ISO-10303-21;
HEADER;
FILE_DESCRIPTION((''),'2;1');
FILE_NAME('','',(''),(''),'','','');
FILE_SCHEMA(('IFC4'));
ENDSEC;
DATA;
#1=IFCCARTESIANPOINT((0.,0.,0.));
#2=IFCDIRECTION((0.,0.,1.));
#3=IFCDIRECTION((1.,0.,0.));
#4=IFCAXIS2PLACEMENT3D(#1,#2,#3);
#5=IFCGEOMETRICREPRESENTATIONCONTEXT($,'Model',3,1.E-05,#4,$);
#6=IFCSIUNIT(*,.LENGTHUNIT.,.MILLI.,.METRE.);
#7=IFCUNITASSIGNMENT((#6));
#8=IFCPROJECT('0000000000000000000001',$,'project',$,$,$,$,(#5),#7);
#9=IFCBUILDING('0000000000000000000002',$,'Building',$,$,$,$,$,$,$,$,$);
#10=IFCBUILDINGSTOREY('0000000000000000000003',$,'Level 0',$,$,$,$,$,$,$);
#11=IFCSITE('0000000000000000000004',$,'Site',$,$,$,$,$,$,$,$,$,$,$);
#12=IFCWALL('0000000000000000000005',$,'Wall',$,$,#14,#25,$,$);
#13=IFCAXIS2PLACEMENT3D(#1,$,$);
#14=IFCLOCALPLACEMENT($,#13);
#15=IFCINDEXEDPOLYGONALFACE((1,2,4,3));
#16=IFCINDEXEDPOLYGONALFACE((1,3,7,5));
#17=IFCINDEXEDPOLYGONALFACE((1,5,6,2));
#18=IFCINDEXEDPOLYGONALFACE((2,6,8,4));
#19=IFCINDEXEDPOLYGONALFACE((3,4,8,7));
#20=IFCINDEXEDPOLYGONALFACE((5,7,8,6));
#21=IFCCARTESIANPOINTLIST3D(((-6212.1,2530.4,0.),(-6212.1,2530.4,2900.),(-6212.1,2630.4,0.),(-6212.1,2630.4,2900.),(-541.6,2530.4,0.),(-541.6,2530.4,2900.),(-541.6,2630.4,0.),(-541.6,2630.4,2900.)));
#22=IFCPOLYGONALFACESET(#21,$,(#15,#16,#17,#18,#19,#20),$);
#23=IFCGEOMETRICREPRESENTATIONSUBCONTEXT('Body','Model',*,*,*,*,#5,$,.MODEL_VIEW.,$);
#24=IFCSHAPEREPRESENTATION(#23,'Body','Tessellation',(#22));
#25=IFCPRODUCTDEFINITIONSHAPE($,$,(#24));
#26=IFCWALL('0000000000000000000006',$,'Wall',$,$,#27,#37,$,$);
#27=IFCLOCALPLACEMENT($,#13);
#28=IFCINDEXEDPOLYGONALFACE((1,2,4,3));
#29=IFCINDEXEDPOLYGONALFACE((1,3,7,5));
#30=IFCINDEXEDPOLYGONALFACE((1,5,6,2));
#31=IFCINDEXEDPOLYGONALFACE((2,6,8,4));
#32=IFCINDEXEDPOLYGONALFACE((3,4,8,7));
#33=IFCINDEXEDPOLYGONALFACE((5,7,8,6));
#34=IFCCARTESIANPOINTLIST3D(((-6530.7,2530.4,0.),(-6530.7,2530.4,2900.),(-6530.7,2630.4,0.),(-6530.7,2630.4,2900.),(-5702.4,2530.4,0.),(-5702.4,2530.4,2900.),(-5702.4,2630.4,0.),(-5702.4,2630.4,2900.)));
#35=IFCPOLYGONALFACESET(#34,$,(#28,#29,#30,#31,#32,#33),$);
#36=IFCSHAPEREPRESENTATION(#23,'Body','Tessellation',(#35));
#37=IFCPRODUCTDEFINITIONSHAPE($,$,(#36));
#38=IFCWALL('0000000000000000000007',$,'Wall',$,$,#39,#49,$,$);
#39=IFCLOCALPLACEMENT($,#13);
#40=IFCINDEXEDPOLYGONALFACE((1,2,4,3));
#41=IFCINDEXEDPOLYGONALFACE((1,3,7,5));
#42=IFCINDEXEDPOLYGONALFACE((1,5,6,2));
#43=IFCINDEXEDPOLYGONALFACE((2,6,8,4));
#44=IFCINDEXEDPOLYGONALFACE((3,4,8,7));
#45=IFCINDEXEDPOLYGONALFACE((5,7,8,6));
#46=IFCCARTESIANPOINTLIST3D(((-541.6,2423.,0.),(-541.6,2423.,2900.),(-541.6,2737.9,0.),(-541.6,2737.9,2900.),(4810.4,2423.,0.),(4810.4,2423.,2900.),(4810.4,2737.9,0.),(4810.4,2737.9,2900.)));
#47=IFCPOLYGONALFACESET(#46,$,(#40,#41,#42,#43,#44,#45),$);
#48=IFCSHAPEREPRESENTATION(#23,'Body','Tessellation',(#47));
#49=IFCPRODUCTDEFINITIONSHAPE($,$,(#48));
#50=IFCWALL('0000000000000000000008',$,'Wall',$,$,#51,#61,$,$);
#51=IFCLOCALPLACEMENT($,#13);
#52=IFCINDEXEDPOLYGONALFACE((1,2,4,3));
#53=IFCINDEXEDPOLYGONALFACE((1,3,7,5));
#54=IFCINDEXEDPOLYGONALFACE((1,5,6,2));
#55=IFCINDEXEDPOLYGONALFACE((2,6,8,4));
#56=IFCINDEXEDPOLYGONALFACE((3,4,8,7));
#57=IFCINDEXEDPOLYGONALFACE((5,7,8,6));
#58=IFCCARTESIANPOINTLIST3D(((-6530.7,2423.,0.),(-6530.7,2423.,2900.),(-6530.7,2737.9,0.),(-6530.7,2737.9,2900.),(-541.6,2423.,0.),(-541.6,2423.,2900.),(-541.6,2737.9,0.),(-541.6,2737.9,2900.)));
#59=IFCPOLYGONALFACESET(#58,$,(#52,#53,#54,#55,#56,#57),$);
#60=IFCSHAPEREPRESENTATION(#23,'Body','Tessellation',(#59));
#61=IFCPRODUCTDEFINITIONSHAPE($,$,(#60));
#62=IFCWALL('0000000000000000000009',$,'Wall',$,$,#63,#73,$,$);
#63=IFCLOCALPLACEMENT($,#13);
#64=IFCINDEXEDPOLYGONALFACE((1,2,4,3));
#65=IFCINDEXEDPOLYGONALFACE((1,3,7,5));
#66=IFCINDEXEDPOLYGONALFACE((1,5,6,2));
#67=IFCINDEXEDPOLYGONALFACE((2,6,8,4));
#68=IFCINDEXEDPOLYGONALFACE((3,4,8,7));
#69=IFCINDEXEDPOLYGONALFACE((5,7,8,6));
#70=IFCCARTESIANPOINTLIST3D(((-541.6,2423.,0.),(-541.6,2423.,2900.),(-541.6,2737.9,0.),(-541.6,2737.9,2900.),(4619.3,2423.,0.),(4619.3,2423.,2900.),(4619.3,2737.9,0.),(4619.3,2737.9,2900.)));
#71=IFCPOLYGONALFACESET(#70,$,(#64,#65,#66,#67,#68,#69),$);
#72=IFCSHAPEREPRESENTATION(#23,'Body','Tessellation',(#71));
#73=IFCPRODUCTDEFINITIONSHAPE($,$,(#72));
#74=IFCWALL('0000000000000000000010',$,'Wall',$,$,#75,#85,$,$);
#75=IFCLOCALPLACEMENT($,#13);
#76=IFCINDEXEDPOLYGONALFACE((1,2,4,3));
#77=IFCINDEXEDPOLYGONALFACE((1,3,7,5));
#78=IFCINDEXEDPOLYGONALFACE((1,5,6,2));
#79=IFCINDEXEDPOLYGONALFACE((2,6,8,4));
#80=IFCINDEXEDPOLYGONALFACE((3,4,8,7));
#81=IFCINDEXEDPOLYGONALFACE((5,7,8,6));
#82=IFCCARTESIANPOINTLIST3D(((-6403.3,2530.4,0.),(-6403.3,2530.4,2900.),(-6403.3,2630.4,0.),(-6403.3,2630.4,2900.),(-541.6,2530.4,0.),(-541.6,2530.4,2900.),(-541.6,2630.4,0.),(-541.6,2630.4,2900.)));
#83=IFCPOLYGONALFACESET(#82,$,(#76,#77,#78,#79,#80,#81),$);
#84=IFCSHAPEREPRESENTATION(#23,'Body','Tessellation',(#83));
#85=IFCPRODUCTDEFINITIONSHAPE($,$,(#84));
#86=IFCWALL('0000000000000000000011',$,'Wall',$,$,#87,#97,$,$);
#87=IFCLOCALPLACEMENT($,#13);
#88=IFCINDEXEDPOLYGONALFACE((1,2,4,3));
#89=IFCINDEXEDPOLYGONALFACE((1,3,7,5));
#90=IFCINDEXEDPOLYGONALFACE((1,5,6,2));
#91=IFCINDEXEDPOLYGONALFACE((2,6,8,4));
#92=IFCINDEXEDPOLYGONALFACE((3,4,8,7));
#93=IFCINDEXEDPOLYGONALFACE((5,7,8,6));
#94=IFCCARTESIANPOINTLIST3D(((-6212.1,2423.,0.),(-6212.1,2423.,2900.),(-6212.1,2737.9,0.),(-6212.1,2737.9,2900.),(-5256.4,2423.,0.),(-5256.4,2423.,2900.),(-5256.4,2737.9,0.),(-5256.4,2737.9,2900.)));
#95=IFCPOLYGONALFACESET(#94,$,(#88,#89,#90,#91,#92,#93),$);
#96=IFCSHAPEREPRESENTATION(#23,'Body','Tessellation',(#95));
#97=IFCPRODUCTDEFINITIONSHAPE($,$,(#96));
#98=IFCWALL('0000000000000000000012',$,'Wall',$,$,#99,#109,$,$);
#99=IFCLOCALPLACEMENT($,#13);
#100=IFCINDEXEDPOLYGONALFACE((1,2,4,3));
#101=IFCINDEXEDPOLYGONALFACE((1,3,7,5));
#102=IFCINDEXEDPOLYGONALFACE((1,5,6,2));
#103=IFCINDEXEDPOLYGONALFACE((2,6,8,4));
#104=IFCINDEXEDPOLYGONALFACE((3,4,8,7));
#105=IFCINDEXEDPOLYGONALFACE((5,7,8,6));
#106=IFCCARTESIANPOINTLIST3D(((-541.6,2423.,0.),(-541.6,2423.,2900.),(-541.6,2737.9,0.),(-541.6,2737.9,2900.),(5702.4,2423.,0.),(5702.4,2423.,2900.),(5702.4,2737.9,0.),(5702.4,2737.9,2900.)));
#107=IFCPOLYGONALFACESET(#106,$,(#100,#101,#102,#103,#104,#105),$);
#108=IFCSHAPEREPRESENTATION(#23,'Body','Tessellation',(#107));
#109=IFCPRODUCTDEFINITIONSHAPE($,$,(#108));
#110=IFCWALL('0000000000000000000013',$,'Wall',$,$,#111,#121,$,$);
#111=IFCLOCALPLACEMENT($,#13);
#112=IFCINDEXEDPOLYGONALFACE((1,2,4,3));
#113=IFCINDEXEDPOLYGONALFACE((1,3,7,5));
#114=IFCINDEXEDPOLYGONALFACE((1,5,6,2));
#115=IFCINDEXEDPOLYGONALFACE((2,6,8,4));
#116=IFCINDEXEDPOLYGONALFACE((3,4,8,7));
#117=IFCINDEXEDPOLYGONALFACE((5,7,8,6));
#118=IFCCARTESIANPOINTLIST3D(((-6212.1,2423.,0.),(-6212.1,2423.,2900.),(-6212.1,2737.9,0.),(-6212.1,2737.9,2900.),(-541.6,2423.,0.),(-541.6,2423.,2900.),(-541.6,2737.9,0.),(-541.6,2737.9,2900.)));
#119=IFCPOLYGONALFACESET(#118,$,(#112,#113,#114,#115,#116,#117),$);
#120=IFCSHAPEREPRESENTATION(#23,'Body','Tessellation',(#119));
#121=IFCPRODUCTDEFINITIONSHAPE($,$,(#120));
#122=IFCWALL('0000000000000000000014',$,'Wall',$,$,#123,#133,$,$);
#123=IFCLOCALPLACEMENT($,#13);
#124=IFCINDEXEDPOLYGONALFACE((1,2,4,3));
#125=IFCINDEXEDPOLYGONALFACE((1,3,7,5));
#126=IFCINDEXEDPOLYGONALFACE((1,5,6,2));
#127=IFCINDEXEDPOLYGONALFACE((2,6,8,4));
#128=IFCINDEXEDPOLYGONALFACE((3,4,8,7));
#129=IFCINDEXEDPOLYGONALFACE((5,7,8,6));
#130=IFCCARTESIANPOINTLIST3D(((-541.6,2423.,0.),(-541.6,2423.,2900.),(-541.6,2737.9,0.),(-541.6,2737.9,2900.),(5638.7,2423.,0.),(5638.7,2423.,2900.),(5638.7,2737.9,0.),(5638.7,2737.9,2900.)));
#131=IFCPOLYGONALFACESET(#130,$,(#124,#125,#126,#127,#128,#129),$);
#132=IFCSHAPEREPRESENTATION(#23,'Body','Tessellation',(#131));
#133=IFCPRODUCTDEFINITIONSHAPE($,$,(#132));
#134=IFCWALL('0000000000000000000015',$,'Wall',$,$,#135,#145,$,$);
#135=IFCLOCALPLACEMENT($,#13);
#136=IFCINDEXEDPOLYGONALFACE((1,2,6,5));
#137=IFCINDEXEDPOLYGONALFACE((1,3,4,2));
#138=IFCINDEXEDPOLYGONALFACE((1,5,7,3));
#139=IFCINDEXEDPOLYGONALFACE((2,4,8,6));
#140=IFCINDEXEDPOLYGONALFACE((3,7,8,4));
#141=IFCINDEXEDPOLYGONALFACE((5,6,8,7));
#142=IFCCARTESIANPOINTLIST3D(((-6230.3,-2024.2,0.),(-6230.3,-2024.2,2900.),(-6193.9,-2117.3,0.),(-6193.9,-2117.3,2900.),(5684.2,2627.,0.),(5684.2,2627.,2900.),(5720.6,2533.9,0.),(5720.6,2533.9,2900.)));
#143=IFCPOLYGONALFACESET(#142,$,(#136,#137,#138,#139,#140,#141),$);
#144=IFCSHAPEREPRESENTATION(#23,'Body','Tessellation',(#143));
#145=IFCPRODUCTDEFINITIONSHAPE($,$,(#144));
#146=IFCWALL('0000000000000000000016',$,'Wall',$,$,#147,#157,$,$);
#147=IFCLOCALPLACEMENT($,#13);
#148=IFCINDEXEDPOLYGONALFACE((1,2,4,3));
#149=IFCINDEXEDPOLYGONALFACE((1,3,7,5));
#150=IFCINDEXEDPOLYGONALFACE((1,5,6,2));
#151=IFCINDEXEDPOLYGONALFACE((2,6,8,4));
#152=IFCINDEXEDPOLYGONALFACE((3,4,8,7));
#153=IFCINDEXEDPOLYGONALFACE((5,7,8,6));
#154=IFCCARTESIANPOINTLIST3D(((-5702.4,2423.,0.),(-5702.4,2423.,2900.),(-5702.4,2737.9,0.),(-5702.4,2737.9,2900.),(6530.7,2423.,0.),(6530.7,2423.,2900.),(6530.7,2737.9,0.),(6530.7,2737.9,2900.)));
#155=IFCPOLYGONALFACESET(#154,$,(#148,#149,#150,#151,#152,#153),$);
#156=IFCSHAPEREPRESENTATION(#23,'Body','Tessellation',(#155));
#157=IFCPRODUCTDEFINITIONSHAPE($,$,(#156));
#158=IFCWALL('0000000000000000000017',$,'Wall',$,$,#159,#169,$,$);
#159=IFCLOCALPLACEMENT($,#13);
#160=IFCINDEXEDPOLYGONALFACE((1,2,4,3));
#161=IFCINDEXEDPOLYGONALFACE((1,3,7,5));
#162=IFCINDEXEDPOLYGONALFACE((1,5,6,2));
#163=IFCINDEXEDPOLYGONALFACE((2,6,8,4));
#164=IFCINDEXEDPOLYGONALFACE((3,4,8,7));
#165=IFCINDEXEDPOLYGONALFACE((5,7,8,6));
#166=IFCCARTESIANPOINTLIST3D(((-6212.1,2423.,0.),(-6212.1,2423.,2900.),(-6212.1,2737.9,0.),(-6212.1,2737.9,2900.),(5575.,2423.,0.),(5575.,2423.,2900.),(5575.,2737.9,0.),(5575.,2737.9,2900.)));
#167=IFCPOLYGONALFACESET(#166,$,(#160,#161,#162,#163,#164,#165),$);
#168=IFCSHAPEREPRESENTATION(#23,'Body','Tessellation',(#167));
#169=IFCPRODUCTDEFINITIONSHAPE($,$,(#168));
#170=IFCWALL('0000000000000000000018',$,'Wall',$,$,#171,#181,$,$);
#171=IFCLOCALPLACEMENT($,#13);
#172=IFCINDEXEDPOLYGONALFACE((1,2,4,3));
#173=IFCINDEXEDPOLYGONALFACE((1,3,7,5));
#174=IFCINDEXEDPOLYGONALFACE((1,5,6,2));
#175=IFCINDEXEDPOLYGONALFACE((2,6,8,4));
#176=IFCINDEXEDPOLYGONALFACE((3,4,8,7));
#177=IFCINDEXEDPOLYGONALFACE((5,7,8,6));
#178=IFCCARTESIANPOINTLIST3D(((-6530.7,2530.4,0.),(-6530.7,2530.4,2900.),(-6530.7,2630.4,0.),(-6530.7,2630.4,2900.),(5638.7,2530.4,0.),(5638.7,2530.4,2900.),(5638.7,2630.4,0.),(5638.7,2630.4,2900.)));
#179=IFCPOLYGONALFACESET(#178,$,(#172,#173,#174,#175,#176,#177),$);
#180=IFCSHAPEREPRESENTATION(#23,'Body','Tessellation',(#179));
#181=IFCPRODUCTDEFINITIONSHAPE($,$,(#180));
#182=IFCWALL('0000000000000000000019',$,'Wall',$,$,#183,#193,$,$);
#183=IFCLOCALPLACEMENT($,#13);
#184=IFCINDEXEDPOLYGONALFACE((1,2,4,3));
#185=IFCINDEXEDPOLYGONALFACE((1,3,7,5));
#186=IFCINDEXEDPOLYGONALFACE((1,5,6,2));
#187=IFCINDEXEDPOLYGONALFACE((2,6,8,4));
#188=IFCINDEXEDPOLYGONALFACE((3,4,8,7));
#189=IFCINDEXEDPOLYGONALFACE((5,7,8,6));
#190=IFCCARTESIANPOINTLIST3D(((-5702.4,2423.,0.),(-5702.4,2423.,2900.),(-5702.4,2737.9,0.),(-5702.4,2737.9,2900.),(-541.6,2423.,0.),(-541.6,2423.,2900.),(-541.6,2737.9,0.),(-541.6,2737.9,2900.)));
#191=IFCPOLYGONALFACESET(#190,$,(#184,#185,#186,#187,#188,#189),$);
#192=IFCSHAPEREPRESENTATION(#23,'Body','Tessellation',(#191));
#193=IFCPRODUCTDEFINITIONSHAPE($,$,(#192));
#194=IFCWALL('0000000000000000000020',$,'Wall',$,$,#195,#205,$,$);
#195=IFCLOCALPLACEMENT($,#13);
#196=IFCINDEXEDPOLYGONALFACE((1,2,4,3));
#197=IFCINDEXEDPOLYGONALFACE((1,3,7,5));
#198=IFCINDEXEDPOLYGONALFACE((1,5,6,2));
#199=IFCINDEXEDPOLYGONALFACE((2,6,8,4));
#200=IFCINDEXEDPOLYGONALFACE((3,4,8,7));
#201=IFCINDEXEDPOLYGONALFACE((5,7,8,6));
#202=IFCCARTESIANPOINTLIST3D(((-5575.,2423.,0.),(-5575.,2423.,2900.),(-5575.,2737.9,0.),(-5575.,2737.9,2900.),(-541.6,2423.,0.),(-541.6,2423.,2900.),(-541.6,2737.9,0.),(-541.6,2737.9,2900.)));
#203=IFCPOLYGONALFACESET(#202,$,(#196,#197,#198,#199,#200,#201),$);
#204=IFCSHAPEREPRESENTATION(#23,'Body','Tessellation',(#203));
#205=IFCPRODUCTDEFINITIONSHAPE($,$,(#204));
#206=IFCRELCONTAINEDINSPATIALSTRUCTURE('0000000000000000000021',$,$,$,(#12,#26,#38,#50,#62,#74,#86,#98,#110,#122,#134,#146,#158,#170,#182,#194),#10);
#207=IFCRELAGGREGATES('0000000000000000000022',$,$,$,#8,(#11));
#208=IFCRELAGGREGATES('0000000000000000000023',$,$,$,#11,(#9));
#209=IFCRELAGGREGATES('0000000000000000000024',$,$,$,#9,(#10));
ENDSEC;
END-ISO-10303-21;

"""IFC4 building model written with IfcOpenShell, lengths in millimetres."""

from ifc_helpers import new_model, si_unit, frame, origin_with_axes, place, context, subcontext, project, spatial, indexed_curve, outline, extrude, element, save


model = new_model("IFC4")

# Units and contexts
model_context = context("Model", 3, precision=1e-05, world=origin_with_axes())
body_context = subcontext(model_context, "Body", "Model", "MODEL_VIEW")
ifc_project = project(units=[si_unit("LENGTHUNIT", "METRE", prefix="MILLI")], contexts=[model_context])

# Site, building, storey
site = spatial("IfcSite", under=ifc_project, Name="Site")
building = spatial("IfcBuilding", under=site, Name="Building")
storey = spatial("IfcBuildingStorey", under=building, Name="Level 0")

# Walls
wall_1_placement = place(None, frame((-6212.1, 2530.4, 0.0), z_axis=(0.0, 0.0, 1.0), x_axis=(1.0, 0.0, 0.0)))
element("IfcWall", 1, at=wall_1_placement, inside=storey, Name="Wall", context=body_context, shape_type="SweptSolid", body=[
    extrude(outline(indexed_curve([(0.0, 0.0), (0.0, 99.9), (5670.5, 99.9), (5670.5, 0.0), (0.0, 0.0)], self_intersect=False)), origin_with_axes(), (0.0, 0.0, 1.0), 2900.0),
])
wall_2_placement = place(None, frame((-6530.7, 2530.4, 0.0), z_axis=(0.0, 0.0, 1.0), x_axis=(1.0, 0.0, 0.0)))
element("IfcWall", 2, at=wall_2_placement, inside=storey, Name="Wall", context=body_context, shape_type="SweptSolid", body=[
    extrude(outline(indexed_curve([(0.0, 0.0), (0.0, 99.9), (828.3, 99.9), (828.3, 0.0), (0.0, 0.0)], self_intersect=False)), origin_with_axes(), (0.0, 0.0, 1.0), 2900.0),
])
wall_3_placement = place(None, frame((-541.6, 2423.0, 0.0), z_axis=(0.0, 0.0, 1.0), x_axis=(1.0, 0.0, 0.0)))
element("IfcWall", 3, at=wall_3_placement, inside=storey, Name="Wall", context=body_context, shape_type="SweptSolid", body=[
    extrude(outline(indexed_curve([(0.0, 0.0), (0.0, 314.9), (5352.0, 314.9), (5352.0, 0.0), (0.0, 0.0)], self_intersect=False)), origin_with_axes(), (0.0, 0.0, 1.0), 2900.0),
])
wall_4_placement = place(None, frame((-6530.7, 2423.0, 0.0), z_axis=(0.0, 0.0, 1.0), x_axis=(1.0, 0.0, 0.0)))
element("IfcWall", 4, at=wall_4_placement, inside=storey, Name="Wall", context=body_context, shape_type="SweptSolid", body=[
    extrude(outline(indexed_curve([(0.0, 0.0), (0.0, 314.9), (5989.1, 314.9), (5989.1, 0.0), (0.0, 0.0)], self_intersect=False)), origin_with_axes(), (0.0, 0.0, 1.0), 2900.0),
])
wall_5_placement = place(None, frame((-541.6, 2423.0, 0.0), z_axis=(0.0, 0.0, 1.0), x_axis=(1.0, 0.0, 0.0)))
element("IfcWall", 5, at=wall_5_placement, inside=storey, Name="Wall", context=body_context, shape_type="SweptSolid", body=[
    extrude(outline(indexed_curve([(0.0, 0.0), (0.0, 314.9), (5160.8, 314.9), (5160.8, 0.0), (0.0, 0.0)], self_intersect=False)), origin_with_axes(), (0.0, 0.0, 1.0), 2900.0),
])
wall_6_placement = place(None, frame((-6403.3, 2530.4, 0.0), z_axis=(0.0, 0.0, 1.0), x_axis=(1.0, 0.0, 0.0)))
element("IfcWall", 6, at=wall_6_placement, inside=storey, Name="Wall", context=body_context, shape_type="SweptSolid", body=[
    extrude(outline(indexed_curve([(0.0, 0.0), (0.0, 99.9), (5861.7, 99.9), (5861.7, 0.0), (0.0, 0.0)], self_intersect=False)), origin_with_axes(), (0.0, 0.0, 1.0), 2900.0),
])
wall_7_placement = place(None, frame((-6212.1, 2423.0, 0.0), z_axis=(0.0, 0.0, 1.0), x_axis=(1.0, 0.0, 0.0)))
element("IfcWall", 7, at=wall_7_placement, inside=storey, Name="Wall", context=body_context, shape_type="SweptSolid", body=[
    extrude(outline(indexed_curve([(0.0, 0.0), (0.0, 314.9), (955.7, 314.9), (955.7, 0.0), (0.0, 0.0)], self_intersect=False)), origin_with_axes(), (0.0, 0.0, 1.0), 2900.0),
])
wall_8_placement = place(None, frame((-541.6, 2423.0, 0.0), z_axis=(0.0, 0.0, 1.0), x_axis=(1.0, 0.0, 0.0)))
element("IfcWall", 8, at=wall_8_placement, inside=storey, Name="Wall", context=body_context, shape_type="SweptSolid", body=[
    extrude(outline(indexed_curve([(0.0, 0.0), (0.0, 314.9), (6244.0, 314.9), (6244.0, 0.0), (0.0, 0.0)], self_intersect=False)), origin_with_axes(), (0.0, 0.0, 1.0), 2900.0),
])
wall_9_placement = place(None, frame((-6212.1, 2423.0, 0.0), z_axis=(0.0, 0.0, 1.0), x_axis=(1.0, 0.0, 0.0)))
element("IfcWall", 9, at=wall_9_placement, inside=storey, Name="Wall", context=body_context, shape_type="SweptSolid", body=[
    extrude(outline(indexed_curve([(0.0, 0.0), (0.0, 314.9), (5670.5, 314.9), (5670.5, 0.0), (0.0, 0.0)], self_intersect=False)), origin_with_axes(), (0.0, 0.0, 1.0), 2900.0),
])
wall_10_placement = place(None, frame((-541.6, 2423.0, 0.0), z_axis=(0.0, 0.0, 1.0), x_axis=(1.0, 0.0, 0.0)))
element("IfcWall", 10, at=wall_10_placement, inside=storey, Name="Wall", context=body_context, shape_type="SweptSolid", body=[
    extrude(outline(indexed_curve([(0.0, 0.0), (0.0, 314.9), (6180.3, 314.9), (6180.3, 0.0), (0.0, 0.0)], self_intersect=False)), origin_with_axes(), (0.0, 0.0, 1.0), 2900.0),
])
wall_11_placement = place(None, frame((-6193.9, -2117.3, 0.0), z_axis=(0.0, 0.0, 1.0), x_axis=(0.931536, 0.363648, 0.0)))
element("IfcWall", 11, at=wall_11_placement, inside=storey, Name="Wall", context=body_context, shape_type="SweptSolid", body=[
    extrude(outline(indexed_curve([(0.0, 0.0), (0.0, 99.9), (12790.2, 99.9), (12790.2, 0.0), (0.0, 0.0)], self_intersect=False)), origin_with_axes(), (0.0, 0.0, 1.0), 2900.0),
])
wall_12_placement = place(None, frame((-5702.4, 2423.0, 0.0), z_axis=(0.0, 0.0, 1.0), x_axis=(1.0, 0.0, 0.0)))
element("IfcWall", 12, at=wall_12_placement, inside=storey, Name="Wall", context=body_context, shape_type="SweptSolid", body=[
    extrude(outline(indexed_curve([(0.0, 0.0), (0.0, 314.9), (12233.1, 314.9), (12233.1, 0.0), (0.0, 0.0)], self_intersect=False)), origin_with_axes(), (0.0, 0.0, 1.0), 2900.0),
])
wall_13_placement = place(None, frame((-6212.1, 2423.0, 0.0), z_axis=(0.0, 0.0, 1.0), x_axis=(1.0, 0.0, 0.0)))
element("IfcWall", 13, at=wall_13_placement, inside=storey, Name="Wall", context=body_context, shape_type="SweptSolid", body=[
    extrude(outline(indexed_curve([(0.0, 0.0), (0.0, 314.9), (11787.1, 314.9), (11787.1, 0.0), (0.0, 0.0)], self_intersect=False)), origin_with_axes(), (0.0, 0.0, 1.0), 2900.0),
])
wall_14_placement = place(None, frame((-6530.7, 2530.4, 0.0), z_axis=(0.0, 0.0, 1.0), x_axis=(1.0, 0.0, 0.0)))
element("IfcWall", 14, at=wall_14_placement, inside=storey, Name="Wall", context=body_context, shape_type="SweptSolid", body=[
    extrude(outline(indexed_curve([(0.0, 0.0), (0.0, 99.9), (12169.4, 99.9), (12169.4, 0.0), (0.0, 0.0)], self_intersect=False)), origin_with_axes(), (0.0, 0.0, 1.0), 2900.0),
])
wall_15_placement = place(None, frame((-5702.4, 2423.0, 0.0), z_axis=(0.0, 0.0, 1.0), x_axis=(1.0, 0.0, 0.0)))
element("IfcWall", 15, at=wall_15_placement, inside=storey, Name="Wall", context=body_context, shape_type="SweptSolid", body=[
    extrude(outline(indexed_curve([(0.0, 0.0), (0.0, 314.9), (5160.8, 314.9), (5160.8, 0.0), (0.0, 0.0)], self_intersect=False)), origin_with_axes(), (0.0, 0.0, 1.0), 2900.0),
])
wall_16_placement = place(None, frame((-5575.0, 2423.0, 0.0), z_axis=(0.0, 0.0, 1.0), x_axis=(1.0, 0.0, 0.0)))
element("IfcWall", 16, at=wall_16_placement, inside=storey, Name="Wall", context=body_context, shape_type="SweptSolid", body=[
    extrude(outline(indexed_curve([(0.0, 0.0), (0.0, 314.9), (5033.4, 314.9), (5033.4, 0.0), (0.0, 0.0)], self_intersect=False)), origin_with_axes(), (0.0, 0.0, 1.0), 2900.0),
])

save(model, "model.ifc")
